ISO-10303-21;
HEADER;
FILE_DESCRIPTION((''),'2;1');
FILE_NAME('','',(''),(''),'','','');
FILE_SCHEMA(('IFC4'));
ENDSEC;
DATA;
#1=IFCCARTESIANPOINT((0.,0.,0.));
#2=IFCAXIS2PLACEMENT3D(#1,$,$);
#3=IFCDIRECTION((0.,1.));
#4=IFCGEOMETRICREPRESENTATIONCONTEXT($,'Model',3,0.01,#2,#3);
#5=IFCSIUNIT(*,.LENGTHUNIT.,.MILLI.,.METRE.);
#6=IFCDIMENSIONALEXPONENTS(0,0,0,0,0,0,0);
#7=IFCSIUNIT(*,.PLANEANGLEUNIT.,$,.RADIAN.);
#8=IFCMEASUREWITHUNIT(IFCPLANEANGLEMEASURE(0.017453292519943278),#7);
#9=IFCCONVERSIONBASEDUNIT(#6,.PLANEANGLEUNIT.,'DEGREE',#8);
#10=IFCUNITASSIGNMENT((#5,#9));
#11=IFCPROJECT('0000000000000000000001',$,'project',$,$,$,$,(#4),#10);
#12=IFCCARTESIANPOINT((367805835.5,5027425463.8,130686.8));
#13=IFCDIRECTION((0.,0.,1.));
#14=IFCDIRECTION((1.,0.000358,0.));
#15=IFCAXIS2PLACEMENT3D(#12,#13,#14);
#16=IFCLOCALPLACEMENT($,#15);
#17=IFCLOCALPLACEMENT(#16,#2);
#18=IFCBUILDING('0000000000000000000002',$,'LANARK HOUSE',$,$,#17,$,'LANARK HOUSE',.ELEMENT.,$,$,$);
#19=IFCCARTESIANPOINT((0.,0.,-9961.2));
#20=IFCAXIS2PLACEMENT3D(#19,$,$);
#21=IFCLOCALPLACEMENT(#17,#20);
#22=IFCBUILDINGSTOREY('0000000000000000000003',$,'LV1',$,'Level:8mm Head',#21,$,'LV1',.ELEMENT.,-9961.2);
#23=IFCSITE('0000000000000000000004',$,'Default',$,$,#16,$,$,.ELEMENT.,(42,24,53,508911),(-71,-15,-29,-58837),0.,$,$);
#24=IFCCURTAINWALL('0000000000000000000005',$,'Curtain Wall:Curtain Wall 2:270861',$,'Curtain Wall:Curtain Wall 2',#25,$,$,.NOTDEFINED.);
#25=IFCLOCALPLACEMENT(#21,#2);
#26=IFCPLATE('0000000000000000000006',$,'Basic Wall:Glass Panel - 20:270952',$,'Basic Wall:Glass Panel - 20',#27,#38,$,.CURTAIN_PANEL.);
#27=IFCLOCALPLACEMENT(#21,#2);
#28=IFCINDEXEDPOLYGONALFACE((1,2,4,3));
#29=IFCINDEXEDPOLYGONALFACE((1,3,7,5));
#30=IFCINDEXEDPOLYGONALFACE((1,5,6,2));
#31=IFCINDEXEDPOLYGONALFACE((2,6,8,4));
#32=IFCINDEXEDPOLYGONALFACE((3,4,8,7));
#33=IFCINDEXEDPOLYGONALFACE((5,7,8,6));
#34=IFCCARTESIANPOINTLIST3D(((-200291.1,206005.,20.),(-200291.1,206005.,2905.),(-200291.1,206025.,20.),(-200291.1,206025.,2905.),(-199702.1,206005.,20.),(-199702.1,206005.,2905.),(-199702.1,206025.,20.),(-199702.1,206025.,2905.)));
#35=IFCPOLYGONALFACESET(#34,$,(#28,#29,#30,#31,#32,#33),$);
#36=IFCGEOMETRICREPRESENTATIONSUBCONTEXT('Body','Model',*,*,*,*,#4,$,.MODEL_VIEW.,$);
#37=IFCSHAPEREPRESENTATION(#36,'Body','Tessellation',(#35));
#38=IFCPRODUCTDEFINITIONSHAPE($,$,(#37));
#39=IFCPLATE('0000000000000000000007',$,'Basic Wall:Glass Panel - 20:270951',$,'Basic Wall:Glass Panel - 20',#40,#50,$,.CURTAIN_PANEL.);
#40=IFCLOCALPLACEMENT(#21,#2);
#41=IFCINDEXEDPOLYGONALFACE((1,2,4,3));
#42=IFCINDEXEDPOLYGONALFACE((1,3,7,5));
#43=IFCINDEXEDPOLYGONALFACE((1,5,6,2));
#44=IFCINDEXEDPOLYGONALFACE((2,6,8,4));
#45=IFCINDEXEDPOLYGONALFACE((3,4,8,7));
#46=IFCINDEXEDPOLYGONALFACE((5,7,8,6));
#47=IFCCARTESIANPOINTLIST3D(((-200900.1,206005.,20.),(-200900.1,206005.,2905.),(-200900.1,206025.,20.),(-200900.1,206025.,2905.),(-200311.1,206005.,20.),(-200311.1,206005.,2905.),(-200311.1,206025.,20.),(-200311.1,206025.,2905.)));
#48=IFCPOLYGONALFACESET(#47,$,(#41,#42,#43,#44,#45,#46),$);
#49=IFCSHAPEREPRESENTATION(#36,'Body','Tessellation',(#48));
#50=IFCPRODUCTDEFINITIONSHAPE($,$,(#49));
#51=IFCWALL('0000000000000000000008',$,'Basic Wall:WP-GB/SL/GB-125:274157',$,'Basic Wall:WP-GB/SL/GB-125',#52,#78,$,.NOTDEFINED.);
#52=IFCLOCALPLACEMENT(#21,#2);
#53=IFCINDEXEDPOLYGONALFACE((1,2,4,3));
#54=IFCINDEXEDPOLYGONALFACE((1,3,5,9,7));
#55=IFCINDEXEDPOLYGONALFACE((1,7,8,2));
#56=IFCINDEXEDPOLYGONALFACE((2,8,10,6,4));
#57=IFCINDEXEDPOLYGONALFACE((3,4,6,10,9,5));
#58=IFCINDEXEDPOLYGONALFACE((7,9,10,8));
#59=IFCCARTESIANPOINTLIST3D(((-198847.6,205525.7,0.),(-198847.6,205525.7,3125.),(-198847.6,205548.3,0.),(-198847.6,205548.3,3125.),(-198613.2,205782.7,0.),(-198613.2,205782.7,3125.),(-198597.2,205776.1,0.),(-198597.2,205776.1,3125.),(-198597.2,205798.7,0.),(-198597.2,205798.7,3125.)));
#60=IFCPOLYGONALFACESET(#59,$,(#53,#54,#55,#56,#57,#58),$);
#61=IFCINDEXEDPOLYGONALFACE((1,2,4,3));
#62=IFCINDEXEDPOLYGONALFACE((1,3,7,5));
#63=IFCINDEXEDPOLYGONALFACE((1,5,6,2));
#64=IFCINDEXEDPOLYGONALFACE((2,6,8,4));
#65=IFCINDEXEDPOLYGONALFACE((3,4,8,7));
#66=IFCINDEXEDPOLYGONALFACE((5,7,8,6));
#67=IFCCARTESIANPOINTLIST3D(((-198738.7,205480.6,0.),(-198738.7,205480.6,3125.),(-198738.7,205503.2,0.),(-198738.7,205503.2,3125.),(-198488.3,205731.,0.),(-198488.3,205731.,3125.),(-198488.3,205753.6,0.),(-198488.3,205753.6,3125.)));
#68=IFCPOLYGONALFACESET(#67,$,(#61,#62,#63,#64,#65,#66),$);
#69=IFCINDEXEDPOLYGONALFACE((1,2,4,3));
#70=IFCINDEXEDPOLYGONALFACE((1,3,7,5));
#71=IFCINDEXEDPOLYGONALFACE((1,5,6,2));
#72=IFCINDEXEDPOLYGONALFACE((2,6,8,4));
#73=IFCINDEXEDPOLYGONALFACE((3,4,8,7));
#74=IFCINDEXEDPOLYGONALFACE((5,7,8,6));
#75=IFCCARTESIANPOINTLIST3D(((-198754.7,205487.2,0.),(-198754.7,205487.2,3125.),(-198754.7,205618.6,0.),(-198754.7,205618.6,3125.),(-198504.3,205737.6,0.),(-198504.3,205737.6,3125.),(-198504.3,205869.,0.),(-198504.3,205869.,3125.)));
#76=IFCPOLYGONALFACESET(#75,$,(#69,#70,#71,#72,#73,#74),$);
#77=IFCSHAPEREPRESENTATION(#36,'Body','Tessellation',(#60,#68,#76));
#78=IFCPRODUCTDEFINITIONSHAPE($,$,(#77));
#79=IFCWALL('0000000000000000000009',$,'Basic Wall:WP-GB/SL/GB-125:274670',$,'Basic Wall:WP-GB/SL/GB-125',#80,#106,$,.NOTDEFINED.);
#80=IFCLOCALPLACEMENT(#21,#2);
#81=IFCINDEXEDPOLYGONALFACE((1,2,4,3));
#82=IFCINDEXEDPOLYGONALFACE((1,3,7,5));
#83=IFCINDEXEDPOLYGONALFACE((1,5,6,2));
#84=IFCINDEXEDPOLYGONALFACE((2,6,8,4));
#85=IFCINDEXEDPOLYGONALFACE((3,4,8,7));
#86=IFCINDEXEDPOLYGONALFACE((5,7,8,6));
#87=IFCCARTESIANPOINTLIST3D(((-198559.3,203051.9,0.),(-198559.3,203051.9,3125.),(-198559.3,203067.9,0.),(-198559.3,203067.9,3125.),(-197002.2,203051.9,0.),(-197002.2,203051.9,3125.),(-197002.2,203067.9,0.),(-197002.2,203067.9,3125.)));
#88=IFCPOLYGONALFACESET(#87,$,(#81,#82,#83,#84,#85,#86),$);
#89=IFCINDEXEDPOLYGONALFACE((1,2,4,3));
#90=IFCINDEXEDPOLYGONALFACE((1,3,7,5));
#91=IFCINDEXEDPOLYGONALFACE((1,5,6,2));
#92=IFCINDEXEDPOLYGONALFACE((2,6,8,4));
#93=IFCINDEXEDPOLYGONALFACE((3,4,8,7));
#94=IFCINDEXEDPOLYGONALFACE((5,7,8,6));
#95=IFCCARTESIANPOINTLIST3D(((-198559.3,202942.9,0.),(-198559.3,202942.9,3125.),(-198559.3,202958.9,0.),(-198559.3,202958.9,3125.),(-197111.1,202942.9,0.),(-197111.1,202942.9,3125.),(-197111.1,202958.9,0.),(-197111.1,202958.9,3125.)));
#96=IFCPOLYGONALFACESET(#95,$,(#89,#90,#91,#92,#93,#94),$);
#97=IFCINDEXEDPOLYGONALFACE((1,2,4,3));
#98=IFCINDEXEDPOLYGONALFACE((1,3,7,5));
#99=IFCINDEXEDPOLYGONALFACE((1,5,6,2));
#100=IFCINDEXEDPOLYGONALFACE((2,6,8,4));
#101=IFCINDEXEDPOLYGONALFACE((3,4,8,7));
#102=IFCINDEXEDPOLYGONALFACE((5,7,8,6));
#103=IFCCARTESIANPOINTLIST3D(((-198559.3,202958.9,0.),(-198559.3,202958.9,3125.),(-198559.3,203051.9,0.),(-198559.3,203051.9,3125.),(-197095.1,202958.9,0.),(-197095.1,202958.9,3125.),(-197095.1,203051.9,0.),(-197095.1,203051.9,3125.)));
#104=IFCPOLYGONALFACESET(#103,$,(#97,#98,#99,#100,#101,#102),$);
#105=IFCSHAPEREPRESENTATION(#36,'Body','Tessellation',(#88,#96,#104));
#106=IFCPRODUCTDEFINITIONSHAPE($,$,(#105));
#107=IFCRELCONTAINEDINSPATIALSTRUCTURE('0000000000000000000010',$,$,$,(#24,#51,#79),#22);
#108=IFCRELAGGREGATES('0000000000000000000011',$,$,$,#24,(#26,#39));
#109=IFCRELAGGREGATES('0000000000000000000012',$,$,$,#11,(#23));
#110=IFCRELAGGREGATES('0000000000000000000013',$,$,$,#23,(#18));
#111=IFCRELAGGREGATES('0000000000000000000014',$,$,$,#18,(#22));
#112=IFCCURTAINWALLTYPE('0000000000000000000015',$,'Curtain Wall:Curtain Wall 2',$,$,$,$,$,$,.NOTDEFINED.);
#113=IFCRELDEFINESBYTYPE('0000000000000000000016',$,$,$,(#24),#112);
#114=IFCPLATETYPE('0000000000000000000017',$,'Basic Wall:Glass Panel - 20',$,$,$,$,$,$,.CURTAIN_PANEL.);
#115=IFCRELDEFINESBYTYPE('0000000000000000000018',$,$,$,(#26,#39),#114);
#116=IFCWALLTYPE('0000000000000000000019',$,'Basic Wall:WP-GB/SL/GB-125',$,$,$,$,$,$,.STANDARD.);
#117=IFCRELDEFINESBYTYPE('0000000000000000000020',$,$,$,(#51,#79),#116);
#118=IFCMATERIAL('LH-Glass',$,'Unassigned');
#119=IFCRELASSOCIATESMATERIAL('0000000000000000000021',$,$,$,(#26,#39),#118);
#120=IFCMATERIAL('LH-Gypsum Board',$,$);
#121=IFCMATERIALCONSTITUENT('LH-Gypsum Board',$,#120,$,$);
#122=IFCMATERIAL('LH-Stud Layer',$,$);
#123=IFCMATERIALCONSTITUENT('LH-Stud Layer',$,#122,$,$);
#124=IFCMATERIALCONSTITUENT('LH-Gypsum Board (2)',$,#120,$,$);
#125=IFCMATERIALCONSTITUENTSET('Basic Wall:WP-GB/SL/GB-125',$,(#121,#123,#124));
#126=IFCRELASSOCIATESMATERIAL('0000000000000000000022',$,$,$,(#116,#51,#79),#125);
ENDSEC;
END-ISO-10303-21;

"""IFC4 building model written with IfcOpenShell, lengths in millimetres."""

from ifc_helpers import new_model, entity, si_unit, converted_unit, direction, frame, origin, place, context, subcontext, project, spatial, indexed_curve, outline, extrude, material, constituent, constituent_set, type_object, element, aggregate, save


model = new_model("IFC4")

# Units and contexts
model_context = context("Model", 3, precision=0.01, world=origin(), true_north=direction((0.0, 1.0)))
body_context = subcontext(model_context, "Body", "Model", "MODEL_VIEW")
ifc_project = project(units=[si_unit("LENGTHUNIT", "METRE", prefix="MILLI"), converted_unit("PLANEANGLEUNIT", "DEGREE", entity("IfcPlaneAngleMeasure", 0.017453292519943278), si_unit("PLANEANGLEUNIT", "RADIAN"), dimensions=[0, 0, 0, 0, 0, 0, 0])], contexts=[model_context])

# Site, building, storey
site_placement = place(None, frame((367805835.5, 5027425463.8, 130686.8), z_axis=(0.0, 0.0, 1.0), x_axis=(1.0, 0.000358, 0.0)))
site = spatial("IfcSite", under=ifc_project, at=site_placement, Name="Default", CompositionType="ELEMENT", RefLatitude=(42, 24, 53, 508911), RefLongitude=(-71, -15, -29, -58837), RefElevation=0.0)
building_placement = place(site_placement, origin())
building = spatial("IfcBuilding", under=site, at=building_placement, Name="LANARK HOUSE", LongName="LANARK HOUSE", CompositionType="ELEMENT")
storey_placement = place(building_placement, frame((0.0, 0.0, -9961.2)))
storey = spatial("IfcBuildingStorey", under=building, at=storey_placement, Name="LV1", ObjectType="Level:8mm Head", LongName="LV1", CompositionType="ELEMENT", Elevation=-9961.2)

# Curtain wall, plates
curtain_wall_type = type_object("IfcCurtainWallType", Name="Curtain Wall:Curtain Wall 2", PredefinedType="NOTDEFINED")
curtain_wall_placement = place(storey_placement, frame((0.0, 0.0, 9961.2)))
curtain_wall = element("IfcCurtainWall", 1, at=curtain_wall_placement, inside=storey, type_object=curtain_wall_type, Name="Curtain Wall:Curtain Wall 2:270861", ObjectType="Curtain Wall:Curtain Wall 2", PredefinedType="NOTDEFINED")
ifc_material_1 = material(Name="LH-Glass", Category="Unassigned")
plate_type = type_object("IfcPlateType", Name="Basic Wall:Glass Panel - 20", PredefinedType="CURTAIN_PANEL")
plate_1_placement = place(storey_placement, frame((-199702.1, 206015.0, 20.0), z_axis=(0.0, 0.0, 1.0), x_axis=(-1.0, 0.0, 0.0)))
plate_1 = element("IfcPlate", 2, at=plate_1_placement, type_object=plate_type, material=ifc_material_1, Name="Basic Wall:Glass Panel - 20:270952", ObjectType="Basic Wall:Glass Panel - 20", PredefinedType="CURTAIN_PANEL", context=body_context, shape_type="SweptSolid", body=[
    extrude(outline(indexed_curve([(-10.0, -294.5), (10.0, -294.5), (10.0, 294.5), (-10.0, 294.5), (-10.0, -294.5)], self_intersect=False)), frame((294.5, 0.0, 0.0), z_axis=(0.0, 0.0, 1.0), x_axis=(0.0, 1.0, 0.0)), (0.0, 0.0, 1.0), 2885.0),
])
plate_2_placement = place(storey_placement, frame((-200311.1, 206015.0, 20.0), z_axis=(0.0, 0.0, 1.0), x_axis=(-1.0, 0.0, 0.0)))
plate_2 = element("IfcPlate", 3, at=plate_2_placement, type_object=plate_type, material=ifc_material_1, Name="Basic Wall:Glass Panel - 20:270951", ObjectType="Basic Wall:Glass Panel - 20", PredefinedType="CURTAIN_PANEL", context=body_context, shape_type="SweptSolid", body=[
    extrude(outline(indexed_curve([(-10.0, -294.5), (10.0, -294.5), (10.0, 294.5), (-10.0, 294.5), (-10.0, -294.5)], self_intersect=False)), frame((294.5, 0.0, 0.0), z_axis=(0.0, 0.0, 1.0), x_axis=(0.0, 1.0, 0.0)), (0.0, 0.0, 1.0), 2885.0),
])
aggregate(curtain_wall, [plate_1, plate_2])

# Shared definitions
ifc_material_2 = material(Name="LH-Gypsum Board")
ifc_material_3 = material(Name="LH-Stud Layer")

# Walls
ifc_constituent_1 = constituent(ifc_material_2, Name="LH-Gypsum Board")
ifc_constituent_2 = constituent(ifc_material_3, Name="LH-Stud Layer")
ifc_constituent_3 = constituent(ifc_material_2, Name="LH-Gypsum Board (2)")
ifc_constituent_set_1 = constituent_set(constituents=[ifc_constituent_1, ifc_constituent_2, ifc_constituent_3], Name="Basic Wall:WP-GB/SL/GB-125")
wall_type_1 = type_object("IfcWallType", Name="Basic Wall:WP-GB/SL/GB-125", PredefinedType="STANDARD", material=ifc_constituent_set_1)
wall_1_placement = place(storey_placement, frame((-198782.8, 205524.7, 0.0), z_axis=(0.0, 0.0, 1.0), x_axis=(0.707107, 0.707107, 0.0)))
element("IfcWall", 4, at=wall_1_placement, inside=storey, type_object=wall_type_1, material=ifc_constituent_set_1, Name="Basic Wall:WP-GB/SL/GB-125:274157", ObjectType="Basic Wall:WP-GB/SL/GB-125", PredefinedType="NOTDEFINED", context=body_context, shape_type="SweptSolid", body=[
    extrude(outline(indexed_curve([(-130.0, -6.4), (201.6, -6.4), (217.6, 9.6), (-136.6, 9.6), (-152.6, -6.4), (-130.0, -6.4)], self_intersect=False)), frame((172.4, 56.1, 0.0), z_axis=(0.0, 0.0, 1.0), x_axis=(-1.0, 0.0, 0.0)), (0.0, 0.0, 1.0), 3125.0),
    extrude(outline(indexed_curve([(113.9, -125.2), (136.5, -125.2), (-113.9, 125.2), (-136.5, 125.2), (113.9, -125.2)], self_intersect=False)), frame((185.1, -54.5, 0.0), z_axis=(0.0, 0.0, 1.0), x_axis=(0.707107, 0.707107, 0.0)), (0.0, 0.0, 1.0), 3125.0),
    extrude(outline(indexed_curve([(-223.5, -46.5), (130.6, -46.5), (223.5, 46.5), (-130.6, 46.5), (-223.5, -46.5)], self_intersect=False)), frame((216.9, 0.0, 0.0)), (0.0, 0.0, 1.0), 3125.0),
])
wall_2_placement = place(storey_placement, frame((-198559.3, 203005.4, 0.0)))
element("IfcWall", 5, at=wall_2_placement, inside=storey, type_object=wall_type_1, material=ifc_constituent_set_1, Name="Basic Wall:WP-GB/SL/GB-125:274670", ObjectType="Basic Wall:WP-GB/SL/GB-125", PredefinedType="NOTDEFINED", context=body_context, shape_type="SweptSolid", body=[
    extrude(outline(indexed_curve([(-8.0, -778.6), (8.0, -778.6), (8.0, 778.6), (-8.0, 778.6), (-8.0, -778.6)], self_intersect=False)), frame((778.6, 54.5, 0.0), z_axis=(0.0, 0.0, 1.0), x_axis=(0.0, -1.0, 0.0)), (0.0, 0.0, 1.0), 3125.0),
    extrude(outline(indexed_curve([(-8.0, -724.1), (8.0, -724.1), (8.0, 724.1), (-8.0, 724.1), (-8.0, -724.1)], self_intersect=False)), frame((724.1, -54.5, 0.0), z_axis=(0.0, 0.0, 1.0), x_axis=(0.0, 1.0, 0.0)), (0.0, 0.0, 1.0), 3125.0),
    extrude(outline(indexed_curve([(-732.1, -46.5), (732.1, -46.5), (732.1, 46.5), (-732.1, 46.5), (-732.1, -46.5)], self_intersect=False)), frame((732.1, 0.0, 0.0)), (0.0, 0.0, 1.0), 3125.0),
])

save(model, "model.ifc")
